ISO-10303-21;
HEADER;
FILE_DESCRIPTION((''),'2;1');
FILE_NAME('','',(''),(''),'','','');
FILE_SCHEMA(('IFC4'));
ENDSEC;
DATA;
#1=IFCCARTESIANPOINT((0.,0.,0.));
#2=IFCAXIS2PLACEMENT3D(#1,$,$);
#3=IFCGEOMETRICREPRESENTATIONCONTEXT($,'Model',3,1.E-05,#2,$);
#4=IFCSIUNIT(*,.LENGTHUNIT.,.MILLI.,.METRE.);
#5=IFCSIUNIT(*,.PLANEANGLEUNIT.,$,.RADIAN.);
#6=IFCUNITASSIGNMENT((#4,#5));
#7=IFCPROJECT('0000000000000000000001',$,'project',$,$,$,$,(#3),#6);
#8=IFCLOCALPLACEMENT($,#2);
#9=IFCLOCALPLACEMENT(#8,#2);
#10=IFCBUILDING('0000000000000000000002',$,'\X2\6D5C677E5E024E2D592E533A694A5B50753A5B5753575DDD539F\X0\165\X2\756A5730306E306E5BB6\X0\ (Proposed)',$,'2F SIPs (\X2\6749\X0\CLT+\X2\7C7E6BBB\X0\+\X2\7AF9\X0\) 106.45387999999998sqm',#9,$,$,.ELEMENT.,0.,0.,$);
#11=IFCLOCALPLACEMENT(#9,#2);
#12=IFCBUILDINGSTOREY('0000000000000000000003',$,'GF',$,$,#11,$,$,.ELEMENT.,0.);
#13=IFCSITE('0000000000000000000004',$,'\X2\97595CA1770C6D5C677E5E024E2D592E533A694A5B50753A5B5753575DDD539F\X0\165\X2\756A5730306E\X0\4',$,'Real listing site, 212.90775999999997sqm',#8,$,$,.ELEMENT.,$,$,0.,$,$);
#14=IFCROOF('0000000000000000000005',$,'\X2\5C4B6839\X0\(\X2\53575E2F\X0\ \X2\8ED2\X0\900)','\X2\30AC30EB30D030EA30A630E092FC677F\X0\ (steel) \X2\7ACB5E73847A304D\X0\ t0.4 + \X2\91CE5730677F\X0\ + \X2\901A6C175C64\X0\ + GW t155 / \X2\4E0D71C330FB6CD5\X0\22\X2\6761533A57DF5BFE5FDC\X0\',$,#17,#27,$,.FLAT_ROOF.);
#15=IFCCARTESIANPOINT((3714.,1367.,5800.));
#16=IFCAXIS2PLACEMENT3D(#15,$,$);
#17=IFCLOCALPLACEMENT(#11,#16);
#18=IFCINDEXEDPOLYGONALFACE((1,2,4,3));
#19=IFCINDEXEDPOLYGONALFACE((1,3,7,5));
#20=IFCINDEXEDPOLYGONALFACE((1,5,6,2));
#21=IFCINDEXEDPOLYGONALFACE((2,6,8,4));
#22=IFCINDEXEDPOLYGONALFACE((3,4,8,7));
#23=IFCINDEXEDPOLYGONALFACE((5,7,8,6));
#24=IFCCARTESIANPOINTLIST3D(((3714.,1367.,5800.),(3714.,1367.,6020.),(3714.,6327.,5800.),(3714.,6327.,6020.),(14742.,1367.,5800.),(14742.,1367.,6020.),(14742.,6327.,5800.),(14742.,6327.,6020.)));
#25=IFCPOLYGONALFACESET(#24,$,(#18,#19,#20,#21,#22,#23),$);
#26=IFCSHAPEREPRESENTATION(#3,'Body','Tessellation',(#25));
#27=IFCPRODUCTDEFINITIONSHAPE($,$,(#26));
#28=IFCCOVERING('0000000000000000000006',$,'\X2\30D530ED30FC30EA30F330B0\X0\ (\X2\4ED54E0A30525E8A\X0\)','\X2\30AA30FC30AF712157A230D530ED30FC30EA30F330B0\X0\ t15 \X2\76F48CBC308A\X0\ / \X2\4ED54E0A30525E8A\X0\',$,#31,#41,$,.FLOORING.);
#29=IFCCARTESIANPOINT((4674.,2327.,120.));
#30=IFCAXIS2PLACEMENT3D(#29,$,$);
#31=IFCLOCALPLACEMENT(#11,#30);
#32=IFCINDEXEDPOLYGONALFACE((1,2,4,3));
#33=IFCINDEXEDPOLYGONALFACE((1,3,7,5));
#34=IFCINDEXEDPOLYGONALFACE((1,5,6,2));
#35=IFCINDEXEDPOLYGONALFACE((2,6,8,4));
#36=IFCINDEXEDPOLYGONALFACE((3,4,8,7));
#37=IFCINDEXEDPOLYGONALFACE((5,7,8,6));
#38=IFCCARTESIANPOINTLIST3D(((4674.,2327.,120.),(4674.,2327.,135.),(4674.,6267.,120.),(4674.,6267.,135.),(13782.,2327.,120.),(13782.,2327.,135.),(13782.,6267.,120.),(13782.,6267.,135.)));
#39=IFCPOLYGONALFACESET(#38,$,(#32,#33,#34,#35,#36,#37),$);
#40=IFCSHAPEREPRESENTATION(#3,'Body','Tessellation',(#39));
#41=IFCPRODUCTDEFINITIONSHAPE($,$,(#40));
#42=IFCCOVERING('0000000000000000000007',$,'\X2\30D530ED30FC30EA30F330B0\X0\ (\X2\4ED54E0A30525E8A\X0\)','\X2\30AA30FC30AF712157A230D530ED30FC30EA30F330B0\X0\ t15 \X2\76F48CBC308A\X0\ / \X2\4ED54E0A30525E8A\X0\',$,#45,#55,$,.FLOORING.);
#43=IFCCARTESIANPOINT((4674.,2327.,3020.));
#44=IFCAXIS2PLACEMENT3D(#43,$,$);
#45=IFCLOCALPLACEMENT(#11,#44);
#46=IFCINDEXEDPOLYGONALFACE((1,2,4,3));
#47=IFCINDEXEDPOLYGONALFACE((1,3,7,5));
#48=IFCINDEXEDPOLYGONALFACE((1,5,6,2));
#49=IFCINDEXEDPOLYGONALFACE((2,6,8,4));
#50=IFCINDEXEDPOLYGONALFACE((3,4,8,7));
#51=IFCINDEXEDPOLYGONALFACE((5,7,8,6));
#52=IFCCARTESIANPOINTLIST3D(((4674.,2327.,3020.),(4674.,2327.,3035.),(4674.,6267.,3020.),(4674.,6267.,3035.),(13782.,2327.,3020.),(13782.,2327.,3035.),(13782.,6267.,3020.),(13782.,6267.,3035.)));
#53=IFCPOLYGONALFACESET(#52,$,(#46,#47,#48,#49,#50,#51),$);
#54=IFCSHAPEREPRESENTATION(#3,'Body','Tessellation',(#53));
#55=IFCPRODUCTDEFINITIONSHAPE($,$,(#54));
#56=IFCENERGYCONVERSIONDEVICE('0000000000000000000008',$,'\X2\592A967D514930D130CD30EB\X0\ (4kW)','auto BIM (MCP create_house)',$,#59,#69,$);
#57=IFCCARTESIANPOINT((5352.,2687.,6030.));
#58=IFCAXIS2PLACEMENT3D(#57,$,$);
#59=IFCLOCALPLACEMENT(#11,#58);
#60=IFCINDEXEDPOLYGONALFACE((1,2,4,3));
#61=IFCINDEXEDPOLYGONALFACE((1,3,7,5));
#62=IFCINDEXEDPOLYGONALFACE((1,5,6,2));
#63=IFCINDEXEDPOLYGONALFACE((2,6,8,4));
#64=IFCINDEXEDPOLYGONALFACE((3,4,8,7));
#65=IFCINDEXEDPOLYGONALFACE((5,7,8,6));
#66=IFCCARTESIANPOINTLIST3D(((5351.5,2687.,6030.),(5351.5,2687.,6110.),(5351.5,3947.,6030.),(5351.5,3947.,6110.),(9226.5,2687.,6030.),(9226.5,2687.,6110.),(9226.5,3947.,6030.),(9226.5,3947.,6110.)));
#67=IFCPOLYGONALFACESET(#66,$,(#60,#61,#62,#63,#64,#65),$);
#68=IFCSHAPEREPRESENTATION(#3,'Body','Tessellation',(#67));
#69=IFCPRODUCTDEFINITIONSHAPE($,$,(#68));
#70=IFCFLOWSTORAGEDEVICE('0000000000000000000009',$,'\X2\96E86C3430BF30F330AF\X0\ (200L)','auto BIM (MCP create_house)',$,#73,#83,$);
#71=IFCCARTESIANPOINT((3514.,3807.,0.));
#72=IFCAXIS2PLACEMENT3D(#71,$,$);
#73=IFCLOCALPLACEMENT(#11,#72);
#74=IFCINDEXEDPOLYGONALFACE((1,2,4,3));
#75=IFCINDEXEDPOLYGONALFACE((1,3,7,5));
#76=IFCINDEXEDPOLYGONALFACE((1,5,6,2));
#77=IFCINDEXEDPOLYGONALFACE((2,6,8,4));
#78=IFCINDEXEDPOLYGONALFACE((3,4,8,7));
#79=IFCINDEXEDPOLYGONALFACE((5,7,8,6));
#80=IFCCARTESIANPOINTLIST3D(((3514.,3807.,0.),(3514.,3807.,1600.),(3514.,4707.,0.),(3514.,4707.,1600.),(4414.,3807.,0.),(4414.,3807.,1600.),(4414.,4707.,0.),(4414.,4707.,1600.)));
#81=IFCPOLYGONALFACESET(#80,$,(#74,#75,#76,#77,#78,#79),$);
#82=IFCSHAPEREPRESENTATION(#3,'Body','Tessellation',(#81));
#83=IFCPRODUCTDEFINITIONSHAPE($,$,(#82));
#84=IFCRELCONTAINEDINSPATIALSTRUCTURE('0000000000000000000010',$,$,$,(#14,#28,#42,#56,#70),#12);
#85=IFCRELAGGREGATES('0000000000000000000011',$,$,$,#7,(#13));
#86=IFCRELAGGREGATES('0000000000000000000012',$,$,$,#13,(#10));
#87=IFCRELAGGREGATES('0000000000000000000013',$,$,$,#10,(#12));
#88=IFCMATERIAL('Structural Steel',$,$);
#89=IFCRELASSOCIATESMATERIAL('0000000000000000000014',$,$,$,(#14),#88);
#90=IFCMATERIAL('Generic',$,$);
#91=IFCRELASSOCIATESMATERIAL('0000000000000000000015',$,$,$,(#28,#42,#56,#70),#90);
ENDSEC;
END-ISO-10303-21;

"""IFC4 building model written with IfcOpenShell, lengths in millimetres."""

from ifc_helpers import new_model, si_unit, frame, frame_2d, origin, place, context, project, spatial, rectangle, extrude, material, element, save


model = new_model("IFC4")

# Units and contexts
model_context = context("Model", 3, precision=1e-05, world=origin())
ifc_project = project(units=[si_unit("LENGTHUNIT", "METRE", prefix="MILLI"), si_unit("PLANEANGLEUNIT", "RADIAN")], contexts=[model_context])

# Site, building, storey
site_placement = place(None, origin())
site = spatial("IfcSite", under=ifc_project, at=site_placement, Name="静岡県浜松市中央区楊子町字南川原165番地の4", ObjectType="Real listing site, 212.90775999999997sqm", CompositionType="ELEMENT", RefElevation=0.0)
building_placement = place(site_placement, origin())
building = spatial("IfcBuilding", under=site, at=building_placement, Name="浜松市中央区楊子町字南川原165番地のの家 (Proposed)", ObjectType="2F SIPs (杉CLT+籾殻+竹) 106.45387999999998sqm", CompositionType="ELEMENT", ElevationOfRefHeight=0.0, ElevationOfTerrain=0.0)
storey_placement = place(building_placement, origin())
storey = spatial("IfcBuildingStorey", under=building, at=storey_placement, Name="GF", CompositionType="ELEMENT", Elevation=0.0)

# Roof
ifc_material_1 = material(Name="Structural Steel")
for number, where, name in (
    (1, (3714.0, 1367.0, 5800.0), "屋根(南帯 軒900)"),
):
    element("IfcRoof", number, at=place(storey_placement, frame(where)), inside=storey, material=ifc_material_1, Name=name, Description="ガルバリウム鋼板 (steel) 立平葺き t0.4 + 野地板 + 通気層 + GW t155 / 不燃・法22条区域対応", PredefinedType="FLAT_ROOF", context=model_context, shape_type="SweptSolid", body=[
        extrude(rectangle(XDim=11028.0, YDim=4960.0, at=frame_2d((5514.0, 2480.0))), frame((3714.0, 1367.0, 5800.0)), (0.0, 0.0, 1.0), 220.0),
    ])

# Coverings
ifc_material_2 = material(Name="Generic")
covering_1_placement = place(storey_placement, frame((4674.0, 2327.0, 120.0)))
element("IfcCovering", 2, at=covering_1_placement, inside=storey, material=ifc_material_2, Name="フローリング (仕上げ床)", Description="オーク無垢フローリング t15 直貼り / 仕上げ床", PredefinedType="FLOORING", context=model_context, shape_type="SweptSolid", body=[
    extrude(rectangle(XDim=9108.0, YDim=3940.0, at=frame_2d((4554.0, 1970.0))), frame((4674.0, 2327.0, 120.0)), (0.0, 0.0, 1.0), 15.0),
])
covering_2_placement = place(storey_placement, frame((4674.0, 2327.0, 3020.0)))
element("IfcCovering", 3, at=covering_2_placement, inside=storey, material=ifc_material_2, Name="フローリング (仕上げ床)", Description="オーク無垢フローリング t15 直貼り / 仕上げ床", PredefinedType="FLOORING", context=model_context, shape_type="SweptSolid", body=[
    extrude(rectangle(XDim=9108.0, YDim=3940.0, at=frame_2d((4554.0, 1970.0))), frame((4674.0, 2327.0, 3020.0)), (0.0, 0.0, 1.0), 15.0),
])

# Energy conversion device
energy_conversion_device_placement = place(storey_placement, frame((5352.0, 2687.0, 6030.0)))
element("IfcEnergyConversionDevice", 4, at=energy_conversion_device_placement, inside=storey, material=ifc_material_2, Name="太陽光パネル (4kW)", Description="auto BIM (MCP create_house)", context=model_context, shape_type="SweptSolid", body=[
    extrude(rectangle(XDim=3875.0, YDim=1260.0, at=frame_2d((1937.0, 630.0))), frame((5352.0, 2687.0, 6030.0)), (0.0, 0.0, 1.0), 80.0),
])

# Flow storage device
flow_storage_device_placement = place(storey_placement, frame((3514.0, 3807.0, 0.0)))
element("IfcFlowStorageDevice", 5, at=flow_storage_device_placement, inside=storey, material=ifc_material_2, Name="雨水タンク (200L)", Description="auto BIM (MCP create_house)", context=model_context, shape_type="SweptSolid", body=[
    extrude(rectangle(XDim=900.0, YDim=900.0, at=frame_2d((450.0, 450.0))), frame((3514.0, 3807.0, 0.0)), (0.0, 0.0, 1.0), 1600.0),
])

save(model, "model.ifc")
